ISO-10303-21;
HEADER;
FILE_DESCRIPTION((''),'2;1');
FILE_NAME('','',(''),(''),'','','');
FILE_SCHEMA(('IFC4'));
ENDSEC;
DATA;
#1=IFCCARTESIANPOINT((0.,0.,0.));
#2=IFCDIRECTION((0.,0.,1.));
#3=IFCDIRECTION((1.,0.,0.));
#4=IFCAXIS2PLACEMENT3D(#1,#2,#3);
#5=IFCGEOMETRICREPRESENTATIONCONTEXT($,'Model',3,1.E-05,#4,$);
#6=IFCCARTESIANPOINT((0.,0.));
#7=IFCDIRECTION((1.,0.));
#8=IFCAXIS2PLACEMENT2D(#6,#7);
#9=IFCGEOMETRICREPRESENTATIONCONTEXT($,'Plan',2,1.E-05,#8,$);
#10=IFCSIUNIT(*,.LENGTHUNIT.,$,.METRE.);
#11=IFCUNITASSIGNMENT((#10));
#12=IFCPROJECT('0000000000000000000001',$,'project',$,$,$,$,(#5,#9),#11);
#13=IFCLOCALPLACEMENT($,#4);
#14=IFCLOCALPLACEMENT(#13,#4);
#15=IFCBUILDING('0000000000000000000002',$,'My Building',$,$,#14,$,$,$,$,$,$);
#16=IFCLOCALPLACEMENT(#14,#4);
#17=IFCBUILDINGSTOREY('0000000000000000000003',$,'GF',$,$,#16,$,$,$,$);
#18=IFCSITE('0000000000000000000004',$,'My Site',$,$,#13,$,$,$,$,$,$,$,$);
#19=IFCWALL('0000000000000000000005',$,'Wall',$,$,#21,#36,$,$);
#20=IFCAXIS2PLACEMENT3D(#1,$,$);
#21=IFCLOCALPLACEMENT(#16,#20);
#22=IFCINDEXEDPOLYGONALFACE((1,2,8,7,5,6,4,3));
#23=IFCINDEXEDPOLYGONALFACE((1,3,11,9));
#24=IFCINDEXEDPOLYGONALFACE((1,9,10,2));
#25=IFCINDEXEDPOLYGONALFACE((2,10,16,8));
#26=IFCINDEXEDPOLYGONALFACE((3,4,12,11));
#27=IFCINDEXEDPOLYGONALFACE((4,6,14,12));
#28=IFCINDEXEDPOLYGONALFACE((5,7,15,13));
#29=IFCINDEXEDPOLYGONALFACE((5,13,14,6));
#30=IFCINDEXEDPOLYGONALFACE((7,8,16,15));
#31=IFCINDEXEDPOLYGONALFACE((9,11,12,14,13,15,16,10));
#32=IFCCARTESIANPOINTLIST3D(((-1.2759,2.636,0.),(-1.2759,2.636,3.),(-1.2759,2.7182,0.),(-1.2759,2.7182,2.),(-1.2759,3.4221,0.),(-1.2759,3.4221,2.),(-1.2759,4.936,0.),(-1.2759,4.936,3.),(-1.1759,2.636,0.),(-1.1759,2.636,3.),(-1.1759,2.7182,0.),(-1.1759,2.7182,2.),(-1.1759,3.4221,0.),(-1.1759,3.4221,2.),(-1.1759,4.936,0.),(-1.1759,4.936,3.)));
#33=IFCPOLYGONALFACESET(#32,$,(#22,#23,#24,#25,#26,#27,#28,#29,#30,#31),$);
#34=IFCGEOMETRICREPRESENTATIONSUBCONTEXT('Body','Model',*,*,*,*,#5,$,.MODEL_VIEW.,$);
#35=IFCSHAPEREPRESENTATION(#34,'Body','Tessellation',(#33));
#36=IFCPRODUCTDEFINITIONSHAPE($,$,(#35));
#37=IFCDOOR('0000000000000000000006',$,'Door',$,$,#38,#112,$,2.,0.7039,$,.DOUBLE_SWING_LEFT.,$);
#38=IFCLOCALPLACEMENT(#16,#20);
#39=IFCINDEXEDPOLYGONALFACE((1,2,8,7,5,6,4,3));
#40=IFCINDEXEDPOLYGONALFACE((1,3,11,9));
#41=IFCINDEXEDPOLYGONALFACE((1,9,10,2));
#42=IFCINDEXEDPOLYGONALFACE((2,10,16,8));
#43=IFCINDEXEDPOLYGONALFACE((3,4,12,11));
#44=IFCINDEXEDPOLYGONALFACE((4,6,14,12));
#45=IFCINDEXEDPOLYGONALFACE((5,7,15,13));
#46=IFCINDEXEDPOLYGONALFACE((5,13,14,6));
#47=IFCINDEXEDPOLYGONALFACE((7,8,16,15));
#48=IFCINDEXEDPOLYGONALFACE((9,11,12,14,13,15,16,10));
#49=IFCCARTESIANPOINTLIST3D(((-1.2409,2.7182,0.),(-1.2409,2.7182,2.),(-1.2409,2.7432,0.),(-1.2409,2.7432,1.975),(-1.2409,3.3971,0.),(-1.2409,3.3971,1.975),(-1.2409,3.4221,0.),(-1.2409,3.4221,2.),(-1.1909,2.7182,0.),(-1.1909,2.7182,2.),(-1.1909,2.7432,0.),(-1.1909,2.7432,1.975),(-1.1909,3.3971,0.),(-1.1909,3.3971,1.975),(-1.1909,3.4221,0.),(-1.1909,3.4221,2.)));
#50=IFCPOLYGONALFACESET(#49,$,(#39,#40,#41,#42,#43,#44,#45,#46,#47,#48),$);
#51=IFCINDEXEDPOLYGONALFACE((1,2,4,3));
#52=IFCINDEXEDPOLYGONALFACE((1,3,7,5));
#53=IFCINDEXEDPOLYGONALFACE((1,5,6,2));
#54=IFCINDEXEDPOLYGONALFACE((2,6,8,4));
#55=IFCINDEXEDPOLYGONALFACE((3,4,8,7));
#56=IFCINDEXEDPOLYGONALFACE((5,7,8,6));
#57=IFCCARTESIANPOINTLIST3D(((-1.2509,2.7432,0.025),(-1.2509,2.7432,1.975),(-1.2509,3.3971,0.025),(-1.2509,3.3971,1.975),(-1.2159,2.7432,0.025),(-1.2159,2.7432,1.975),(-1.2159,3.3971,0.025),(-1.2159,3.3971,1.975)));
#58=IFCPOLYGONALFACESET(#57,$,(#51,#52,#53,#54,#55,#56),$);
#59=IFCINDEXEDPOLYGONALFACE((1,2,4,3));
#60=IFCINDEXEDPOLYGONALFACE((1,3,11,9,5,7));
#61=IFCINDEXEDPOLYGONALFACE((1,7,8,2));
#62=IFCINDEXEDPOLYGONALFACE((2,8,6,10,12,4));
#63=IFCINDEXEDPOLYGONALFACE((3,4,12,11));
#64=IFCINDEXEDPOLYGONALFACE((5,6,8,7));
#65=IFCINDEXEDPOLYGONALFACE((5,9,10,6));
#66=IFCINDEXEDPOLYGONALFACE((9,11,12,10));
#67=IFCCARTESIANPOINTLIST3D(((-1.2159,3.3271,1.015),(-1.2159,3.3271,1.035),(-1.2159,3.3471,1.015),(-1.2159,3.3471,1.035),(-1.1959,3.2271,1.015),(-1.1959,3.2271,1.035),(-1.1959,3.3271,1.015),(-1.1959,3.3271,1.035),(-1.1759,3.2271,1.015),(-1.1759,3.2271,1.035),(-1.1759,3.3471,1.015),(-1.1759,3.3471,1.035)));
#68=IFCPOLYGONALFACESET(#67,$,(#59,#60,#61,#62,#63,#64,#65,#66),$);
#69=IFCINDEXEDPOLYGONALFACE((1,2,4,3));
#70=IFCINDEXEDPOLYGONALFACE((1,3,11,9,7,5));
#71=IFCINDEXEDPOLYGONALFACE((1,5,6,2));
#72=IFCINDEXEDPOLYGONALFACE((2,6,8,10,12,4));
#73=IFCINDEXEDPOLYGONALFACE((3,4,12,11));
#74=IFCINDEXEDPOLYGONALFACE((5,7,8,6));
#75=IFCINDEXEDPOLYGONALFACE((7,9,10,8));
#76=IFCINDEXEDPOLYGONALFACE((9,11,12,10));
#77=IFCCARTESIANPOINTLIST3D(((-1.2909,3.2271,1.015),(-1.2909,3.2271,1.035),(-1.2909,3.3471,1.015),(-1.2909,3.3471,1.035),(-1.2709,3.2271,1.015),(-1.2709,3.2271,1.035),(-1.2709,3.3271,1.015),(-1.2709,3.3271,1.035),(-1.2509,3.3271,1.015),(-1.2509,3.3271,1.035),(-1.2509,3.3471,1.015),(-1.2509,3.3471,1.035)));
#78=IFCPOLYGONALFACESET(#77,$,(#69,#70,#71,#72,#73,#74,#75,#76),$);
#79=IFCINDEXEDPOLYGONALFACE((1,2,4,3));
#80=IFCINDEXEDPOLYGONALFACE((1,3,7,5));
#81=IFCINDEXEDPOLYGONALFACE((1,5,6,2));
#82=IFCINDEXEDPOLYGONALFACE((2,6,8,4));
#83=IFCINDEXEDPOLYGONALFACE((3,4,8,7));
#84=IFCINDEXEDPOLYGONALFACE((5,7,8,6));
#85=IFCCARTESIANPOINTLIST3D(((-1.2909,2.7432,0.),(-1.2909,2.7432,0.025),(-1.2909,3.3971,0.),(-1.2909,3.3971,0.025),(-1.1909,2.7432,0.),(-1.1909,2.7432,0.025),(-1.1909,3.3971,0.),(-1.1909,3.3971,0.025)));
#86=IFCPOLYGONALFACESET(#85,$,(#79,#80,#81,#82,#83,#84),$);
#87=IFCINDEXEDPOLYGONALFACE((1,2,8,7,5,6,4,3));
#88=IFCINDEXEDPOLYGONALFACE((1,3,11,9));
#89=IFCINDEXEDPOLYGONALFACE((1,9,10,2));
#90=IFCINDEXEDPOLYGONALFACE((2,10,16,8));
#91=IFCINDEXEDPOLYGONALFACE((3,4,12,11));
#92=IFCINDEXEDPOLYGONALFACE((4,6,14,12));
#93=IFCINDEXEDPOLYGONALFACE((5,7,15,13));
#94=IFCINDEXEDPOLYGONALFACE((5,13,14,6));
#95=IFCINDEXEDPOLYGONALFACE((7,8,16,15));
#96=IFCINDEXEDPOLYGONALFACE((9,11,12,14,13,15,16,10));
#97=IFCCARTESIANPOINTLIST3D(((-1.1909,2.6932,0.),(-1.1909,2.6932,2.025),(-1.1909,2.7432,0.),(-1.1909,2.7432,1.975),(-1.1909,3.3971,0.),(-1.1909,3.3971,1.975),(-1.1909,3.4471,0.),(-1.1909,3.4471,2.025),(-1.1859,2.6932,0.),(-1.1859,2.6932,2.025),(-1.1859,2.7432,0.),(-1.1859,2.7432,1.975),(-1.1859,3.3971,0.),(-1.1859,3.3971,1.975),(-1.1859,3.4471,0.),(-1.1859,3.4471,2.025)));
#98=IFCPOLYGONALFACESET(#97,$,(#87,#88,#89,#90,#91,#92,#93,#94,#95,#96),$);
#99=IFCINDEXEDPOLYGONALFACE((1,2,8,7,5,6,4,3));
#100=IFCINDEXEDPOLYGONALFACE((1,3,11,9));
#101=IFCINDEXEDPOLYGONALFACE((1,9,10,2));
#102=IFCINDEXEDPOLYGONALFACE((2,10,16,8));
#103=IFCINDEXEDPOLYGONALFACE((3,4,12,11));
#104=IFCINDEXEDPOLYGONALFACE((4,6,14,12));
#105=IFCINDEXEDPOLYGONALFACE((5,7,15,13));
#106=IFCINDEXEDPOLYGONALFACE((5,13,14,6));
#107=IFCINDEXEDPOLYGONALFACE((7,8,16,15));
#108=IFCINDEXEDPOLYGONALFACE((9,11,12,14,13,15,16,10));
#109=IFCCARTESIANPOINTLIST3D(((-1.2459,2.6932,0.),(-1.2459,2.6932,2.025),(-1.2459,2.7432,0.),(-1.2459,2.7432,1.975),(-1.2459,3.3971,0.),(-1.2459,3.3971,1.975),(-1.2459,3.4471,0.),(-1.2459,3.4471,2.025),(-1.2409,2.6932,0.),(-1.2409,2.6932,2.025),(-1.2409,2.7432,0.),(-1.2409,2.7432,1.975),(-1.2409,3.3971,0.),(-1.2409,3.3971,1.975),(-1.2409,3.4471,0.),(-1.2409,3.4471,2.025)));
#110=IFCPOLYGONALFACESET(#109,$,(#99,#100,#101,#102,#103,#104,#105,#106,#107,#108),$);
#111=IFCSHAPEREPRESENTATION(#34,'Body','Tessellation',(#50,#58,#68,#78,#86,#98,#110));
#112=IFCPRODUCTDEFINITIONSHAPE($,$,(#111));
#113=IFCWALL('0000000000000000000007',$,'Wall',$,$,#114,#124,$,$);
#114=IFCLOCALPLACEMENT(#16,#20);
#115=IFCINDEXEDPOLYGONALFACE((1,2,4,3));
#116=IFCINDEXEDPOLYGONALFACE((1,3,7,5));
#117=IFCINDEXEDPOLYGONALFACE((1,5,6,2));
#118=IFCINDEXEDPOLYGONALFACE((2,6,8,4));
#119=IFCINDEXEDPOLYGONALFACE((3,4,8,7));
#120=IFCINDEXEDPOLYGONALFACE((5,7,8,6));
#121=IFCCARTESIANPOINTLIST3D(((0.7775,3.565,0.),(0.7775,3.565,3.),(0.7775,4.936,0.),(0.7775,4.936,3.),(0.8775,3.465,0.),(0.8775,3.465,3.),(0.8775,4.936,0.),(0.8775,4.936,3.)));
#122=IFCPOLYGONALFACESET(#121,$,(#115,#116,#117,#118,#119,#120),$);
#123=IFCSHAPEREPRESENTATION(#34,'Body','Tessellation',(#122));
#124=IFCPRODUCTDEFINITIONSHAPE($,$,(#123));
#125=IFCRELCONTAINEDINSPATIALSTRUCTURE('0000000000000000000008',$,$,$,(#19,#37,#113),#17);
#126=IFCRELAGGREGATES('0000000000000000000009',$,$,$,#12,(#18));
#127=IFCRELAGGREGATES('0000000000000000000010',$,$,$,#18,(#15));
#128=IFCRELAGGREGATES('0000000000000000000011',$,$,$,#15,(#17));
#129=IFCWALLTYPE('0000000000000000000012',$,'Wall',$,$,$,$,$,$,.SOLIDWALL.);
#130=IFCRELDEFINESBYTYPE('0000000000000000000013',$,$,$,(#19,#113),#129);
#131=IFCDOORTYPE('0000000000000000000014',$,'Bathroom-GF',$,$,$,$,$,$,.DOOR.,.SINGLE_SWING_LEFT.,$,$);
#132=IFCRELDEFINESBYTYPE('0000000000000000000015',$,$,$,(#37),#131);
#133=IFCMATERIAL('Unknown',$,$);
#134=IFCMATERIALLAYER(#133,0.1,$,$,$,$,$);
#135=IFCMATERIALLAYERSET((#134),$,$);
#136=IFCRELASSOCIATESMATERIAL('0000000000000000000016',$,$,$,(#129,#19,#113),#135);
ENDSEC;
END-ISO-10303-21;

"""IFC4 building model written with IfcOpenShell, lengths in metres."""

from ifc_helpers import new_model, entity, si_unit, frame, origin_with_axes, origin_2d_with_axis, place, context, subcontext, project, spatial, line, indexed_curve, outline, extrude, shape, source, transform, mapped, material, layer, layer_set, layer_usage, type_object, type_shapes, element, fill, save


model = new_model("IFC4")

# Units and contexts
model_context = context("Model", 3, precision=1e-05, world=origin_with_axes())
plan_context = context("Plan", 2, precision=1e-05, world=origin_2d_with_axis())
body_context_1 = subcontext(model_context, "Body", "Model", "MODEL_VIEW")
body_context_2 = subcontext(plan_context, "Body", "Plan", "PLAN_VIEW")
ifc_project = project(units=[si_unit("LENGTHUNIT", "METRE")], contexts=[model_context, plan_context])

# Site, building, storey
site_placement = place(None, origin_with_axes())
site = spatial("IfcSite", under=ifc_project, at=site_placement, Name="My Site")
building_placement = place(site_placement, origin_with_axes())
building = spatial("IfcBuilding", under=site, at=building_placement, Name="My Building")
storey_placement = place(building_placement, origin_with_axes())
storey = spatial("IfcBuildingStorey", under=building, at=storey_placement, Name="GF")

# Shared definitions
ifc_material = material(Name="Unknown")

# Shared definitions
ifc_layer_1 = layer(ifc_material, 0.1)
ifc_layer_set_1 = layer_set([ifc_layer_1])
wall_type = type_object("IfcWallType", Name="Wall", PredefinedType="SOLIDWALL", material=ifc_layer_set_1)

# Wall, opening, door
ifc_layer_usage_1 = layer_usage(ifc_layer_set_1, "AXIS2", "POSITIVE", 0.0)
wall_1_placement = place(storey_placement, frame((-1.1759, 2.636, 0.0), z_axis=(0.0, 0.0, 1.0), x_axis=(0.0, 1.0, 0.0)))
wall_1 = element("IfcWall", 1, at=wall_1_placement, inside=storey, type_object=wall_type, material=ifc_layer_usage_1, Name="Wall", context=body_context_1, shape_type="SweptSolid", body=[
    extrude(outline(indexed_curve([(0.0, 0.0), (0.0, 0.1), (2.3, 0.1), (2.3, 0.0)], segments=[line(1, 2, 3, 4, 1)])), origin_with_axes(), (0.0, 0.0, 1.0), 3.0),
])
shared_shape_1 = source(origin_with_axes(), body_context_1, "Body", "SweptSolid", [
    extrude(outline(indexed_curve([(0.0, 0.0), (0.7039, 0.0), (0.7039, 2.0), (0.0, 2.0)], segments=[line(1, 2, 3, 4, 1)])), frame((0.0, -0.6, 0.0), z_axis=(0.0, -1.0, 0.0), x_axis=(1.0, 0.0, 0.0)), (0.0, 0.0, -1.0), 1.2),
])
opening_1_placement = place(wall_1_placement, frame((0.0822, 0.015, 0.0), z_axis=(0.0, 0.0, 1.0), x_axis=(1.0, 0.0, 0.0)))
opening_1 = element("IfcOpeningElement", 2, at=opening_1_placement, cuts=wall_1, PredefinedType="OPENING", context=body_context_1, shape_type="MappedRepresentation", body=[
    mapped(shared_shape_1, transform((0.0, 0.0, 0.0), x_axis=(1.0, 0.0, 0.0), y_axis=(0.0, 1.0, 0.0), z_axis=(0.0, 0.0, 1.0), scale=1.0)),
])
door_type_1 = type_object("IfcDoorType", Name="Bathroom-GF", OperationType="SINGLE_SWING_LEFT", PredefinedType="DOOR")
shared_shape_2 = source(origin_with_axes(), body_context_1, "Body", "SweptSolid", [
    extrude(outline(indexed_curve([(0.0, 0.0), (0.0, 2.0), (0.7039, 2.0), (0.7039, 0.0), (0.6789, 0.0), (0.6789, 1.975), (0.025, 1.975), (0.025, 0.0)], segments=[line(1, 2, 3, 4, 5, 6, 7, 8, 1)])), frame((0.0, 0.0, 0.0), z_axis=(0.0, -1.0, 0.0), x_axis=(1.0, 0.0, 0.0)), (0.0, 0.0, -1.0), 0.05),
    extrude(outline(indexed_curve([(0.0, 0.0), (0.6539, 0.0), (0.6539, 0.035), (0.0, 0.035)], segments=[line(1, 2, 3, 4, 1)])), frame((0.025, 0.025, 0.025), z_axis=(0.0, 0.0, 1.0), x_axis=(1.0, 0.0, 0.0)), (0.0, 0.0, 1.0), 1.95),
    extrude(outline(indexed_curve([(0.0, 0.0), (0.0, -0.04), (-0.12, -0.04), (-0.12, -0.02), (-0.02, -0.02), (-0.02, 0.0)], segments=[line(1, 2, 3, 4, 5, 6, 1)])), frame((0.6289, 0.025, 1.015), z_axis=(0.0, 0.0, 1.0), x_axis=(1.0, 0.0, 0.0)), (0.0, 0.0, 1.0), 0.02),
    extrude(outline(indexed_curve([(0.0, 0.0), (0.0, 0.04), (-0.12, 0.04), (-0.12, 0.02), (-0.02, 0.02), (-0.02, 0.0)], segments=[line(1, 2, 3, 4, 5, 6, 1)])), frame((0.6289, 0.06, 1.015), z_axis=(0.0, 0.0, 1.0), x_axis=(1.0, 0.0, 0.0)), (0.0, 0.0, 1.0), 0.02),
    extrude(outline(indexed_curve([(0.0, 0.0), (0.6539, 0.0), (0.6539, 0.1), (0.0, 0.1)], segments=[line(1, 2, 3, 4, 1)])), frame((0.025, 0.0, 0.0), z_axis=(0.0, 0.0, 1.0), x_axis=(1.0, 0.0, 0.0)), (0.0, 0.0, 1.0), 0.025),
    extrude(outline(indexed_curve([(0.0, 0.0), (0.0, 2.025), (0.7539, 2.025), (0.7539, 0.0), (0.7039, 0.0), (0.7039, 1.975), (0.05, 1.975), (0.05, 0.0)], segments=[line(1, 2, 3, 4, 5, 6, 7, 8, 1)])), frame((-0.025, -0.005, 0.0), z_axis=(0.0, -1.0, 0.0), x_axis=(1.0, 0.0, 0.0)), (0.0, 0.0, -1.0), 0.005),
    extrude(outline(indexed_curve([(0.0, 0.0), (0.0, 2.025), (0.7539, 2.025), (0.7539, 0.0), (0.7039, 0.0), (0.7039, 1.975), (0.05, 1.975), (0.05, 0.0)], segments=[line(1, 2, 3, 4, 5, 6, 7, 8, 1)])), frame((-0.025, 0.05, 0.0), z_axis=(0.0, -1.0, 0.0), x_axis=(1.0, 0.0, 0.0)), (0.0, 0.0, -1.0), 0.005),
])
shared_shape_3 = source(origin_with_axes(), body_context_2, "Body", "Curve2D", [
    entity("IfcIndexedPolyCurve", entity("IfcCartesianPointList2D", [[0.0, 0.0], [0.025, 0.0], [0.025, 0.05], [0.0, 0.05]]), [entity("IfcLineIndex", [1, 2, 3, 4, 1])]),
    entity("IfcIndexedPolyCurve", entity("IfcCartesianPointList2D", [[0.7039, 0.0], [0.6789, 0.0], [0.6789, 0.05], [0.7039, 0.05]]), [entity("IfcLineIndex", [1, 2, 3, 4, 1])]),
    entity("IfcIndexedPolyCurve", entity("IfcCartesianPointList2D", [[0.025, 0.05], [0.025, -0.6039], [0.06, -0.6039]])),
    entity("IfcTrimmedCurve", entity("IfcEllipse", entity("IfcAxis2Placement2D", entity("IfcCartesianPoint", [0.06, 0.05]), entity("IfcDirection", [1.0, 0.0])), 0.6189, 0.6539), [entity("IfcCartesianPoint", [0.06, -0.6039])], [entity("IfcCartesianPoint", [0.06, 0.7039])], True, "CARTESIAN"),
    entity("IfcIndexedPolyCurve", entity("IfcCartesianPointList2D", [[0.025, 0.05], [0.06, 0.05], [0.06, 0.7039], [0.025, 0.7039]]), [entity("IfcLineIndex", [1, 2, 3, 4, 1])]),
])
type_shapes(door_type_1, [shared_shape_2, shared_shape_3])
door_1_placement = place(opening_1_placement, origin_with_axes())
door_1 = element("IfcDoor", 3, at=door_1_placement, inside=storey, type_object=door_type_1, Name="Door", OperationType="DOUBLE_SWING_LEFT", OverallHeight=2.0, OverallWidth=0.7039, shapes=[
    shape(body_context_1, "Body", "MappedRepresentation", [mapped(shared_shape_2, transform((0.0, 0.0, 0.0), x_axis=(1.0, 0.0, 0.0), y_axis=(0.0, 1.0, 0.0), z_axis=(0.0, 0.0, 1.0), scale=1.0))]),
    shape(body_context_2, "Body", "MappedRepresentation", [mapped(shared_shape_3, transform((0.0, 0.0, 0.0), x_axis=(1.0, 0.0, 0.0), y_axis=(0.0, 1.0, 0.0), z_axis=(0.0, 0.0, 1.0), scale=1.0))]),
])
fill(opening_1, door_1)

# Wall
ifc_layer_usage_2 = layer_usage(ifc_layer_set_1, "AXIS2", "POSITIVE", 0.0)
wall_2_placement = place(storey_placement, frame((0.7775, 5.036, 0.0), z_axis=(0.0, 0.0, 1.0), x_axis=(0.0, -1.0, 0.0)))
element("IfcWall", 4, at=wall_2_placement, inside=storey, type_object=wall_type, material=ifc_layer_usage_2, Name="Wall", context=body_context_1, shape_type="SweptSolid", body=[
    extrude(outline(indexed_curve([(0.1, 0.0), (0.1, 0.1), (1.5709, 0.1), (1.4709, 0.0)], segments=[line(1, 2, 3, 4, 1)])), origin_with_axes(), (0.0, 0.0, 1.0), 3.0),
])

save(model, "model.ifc")
